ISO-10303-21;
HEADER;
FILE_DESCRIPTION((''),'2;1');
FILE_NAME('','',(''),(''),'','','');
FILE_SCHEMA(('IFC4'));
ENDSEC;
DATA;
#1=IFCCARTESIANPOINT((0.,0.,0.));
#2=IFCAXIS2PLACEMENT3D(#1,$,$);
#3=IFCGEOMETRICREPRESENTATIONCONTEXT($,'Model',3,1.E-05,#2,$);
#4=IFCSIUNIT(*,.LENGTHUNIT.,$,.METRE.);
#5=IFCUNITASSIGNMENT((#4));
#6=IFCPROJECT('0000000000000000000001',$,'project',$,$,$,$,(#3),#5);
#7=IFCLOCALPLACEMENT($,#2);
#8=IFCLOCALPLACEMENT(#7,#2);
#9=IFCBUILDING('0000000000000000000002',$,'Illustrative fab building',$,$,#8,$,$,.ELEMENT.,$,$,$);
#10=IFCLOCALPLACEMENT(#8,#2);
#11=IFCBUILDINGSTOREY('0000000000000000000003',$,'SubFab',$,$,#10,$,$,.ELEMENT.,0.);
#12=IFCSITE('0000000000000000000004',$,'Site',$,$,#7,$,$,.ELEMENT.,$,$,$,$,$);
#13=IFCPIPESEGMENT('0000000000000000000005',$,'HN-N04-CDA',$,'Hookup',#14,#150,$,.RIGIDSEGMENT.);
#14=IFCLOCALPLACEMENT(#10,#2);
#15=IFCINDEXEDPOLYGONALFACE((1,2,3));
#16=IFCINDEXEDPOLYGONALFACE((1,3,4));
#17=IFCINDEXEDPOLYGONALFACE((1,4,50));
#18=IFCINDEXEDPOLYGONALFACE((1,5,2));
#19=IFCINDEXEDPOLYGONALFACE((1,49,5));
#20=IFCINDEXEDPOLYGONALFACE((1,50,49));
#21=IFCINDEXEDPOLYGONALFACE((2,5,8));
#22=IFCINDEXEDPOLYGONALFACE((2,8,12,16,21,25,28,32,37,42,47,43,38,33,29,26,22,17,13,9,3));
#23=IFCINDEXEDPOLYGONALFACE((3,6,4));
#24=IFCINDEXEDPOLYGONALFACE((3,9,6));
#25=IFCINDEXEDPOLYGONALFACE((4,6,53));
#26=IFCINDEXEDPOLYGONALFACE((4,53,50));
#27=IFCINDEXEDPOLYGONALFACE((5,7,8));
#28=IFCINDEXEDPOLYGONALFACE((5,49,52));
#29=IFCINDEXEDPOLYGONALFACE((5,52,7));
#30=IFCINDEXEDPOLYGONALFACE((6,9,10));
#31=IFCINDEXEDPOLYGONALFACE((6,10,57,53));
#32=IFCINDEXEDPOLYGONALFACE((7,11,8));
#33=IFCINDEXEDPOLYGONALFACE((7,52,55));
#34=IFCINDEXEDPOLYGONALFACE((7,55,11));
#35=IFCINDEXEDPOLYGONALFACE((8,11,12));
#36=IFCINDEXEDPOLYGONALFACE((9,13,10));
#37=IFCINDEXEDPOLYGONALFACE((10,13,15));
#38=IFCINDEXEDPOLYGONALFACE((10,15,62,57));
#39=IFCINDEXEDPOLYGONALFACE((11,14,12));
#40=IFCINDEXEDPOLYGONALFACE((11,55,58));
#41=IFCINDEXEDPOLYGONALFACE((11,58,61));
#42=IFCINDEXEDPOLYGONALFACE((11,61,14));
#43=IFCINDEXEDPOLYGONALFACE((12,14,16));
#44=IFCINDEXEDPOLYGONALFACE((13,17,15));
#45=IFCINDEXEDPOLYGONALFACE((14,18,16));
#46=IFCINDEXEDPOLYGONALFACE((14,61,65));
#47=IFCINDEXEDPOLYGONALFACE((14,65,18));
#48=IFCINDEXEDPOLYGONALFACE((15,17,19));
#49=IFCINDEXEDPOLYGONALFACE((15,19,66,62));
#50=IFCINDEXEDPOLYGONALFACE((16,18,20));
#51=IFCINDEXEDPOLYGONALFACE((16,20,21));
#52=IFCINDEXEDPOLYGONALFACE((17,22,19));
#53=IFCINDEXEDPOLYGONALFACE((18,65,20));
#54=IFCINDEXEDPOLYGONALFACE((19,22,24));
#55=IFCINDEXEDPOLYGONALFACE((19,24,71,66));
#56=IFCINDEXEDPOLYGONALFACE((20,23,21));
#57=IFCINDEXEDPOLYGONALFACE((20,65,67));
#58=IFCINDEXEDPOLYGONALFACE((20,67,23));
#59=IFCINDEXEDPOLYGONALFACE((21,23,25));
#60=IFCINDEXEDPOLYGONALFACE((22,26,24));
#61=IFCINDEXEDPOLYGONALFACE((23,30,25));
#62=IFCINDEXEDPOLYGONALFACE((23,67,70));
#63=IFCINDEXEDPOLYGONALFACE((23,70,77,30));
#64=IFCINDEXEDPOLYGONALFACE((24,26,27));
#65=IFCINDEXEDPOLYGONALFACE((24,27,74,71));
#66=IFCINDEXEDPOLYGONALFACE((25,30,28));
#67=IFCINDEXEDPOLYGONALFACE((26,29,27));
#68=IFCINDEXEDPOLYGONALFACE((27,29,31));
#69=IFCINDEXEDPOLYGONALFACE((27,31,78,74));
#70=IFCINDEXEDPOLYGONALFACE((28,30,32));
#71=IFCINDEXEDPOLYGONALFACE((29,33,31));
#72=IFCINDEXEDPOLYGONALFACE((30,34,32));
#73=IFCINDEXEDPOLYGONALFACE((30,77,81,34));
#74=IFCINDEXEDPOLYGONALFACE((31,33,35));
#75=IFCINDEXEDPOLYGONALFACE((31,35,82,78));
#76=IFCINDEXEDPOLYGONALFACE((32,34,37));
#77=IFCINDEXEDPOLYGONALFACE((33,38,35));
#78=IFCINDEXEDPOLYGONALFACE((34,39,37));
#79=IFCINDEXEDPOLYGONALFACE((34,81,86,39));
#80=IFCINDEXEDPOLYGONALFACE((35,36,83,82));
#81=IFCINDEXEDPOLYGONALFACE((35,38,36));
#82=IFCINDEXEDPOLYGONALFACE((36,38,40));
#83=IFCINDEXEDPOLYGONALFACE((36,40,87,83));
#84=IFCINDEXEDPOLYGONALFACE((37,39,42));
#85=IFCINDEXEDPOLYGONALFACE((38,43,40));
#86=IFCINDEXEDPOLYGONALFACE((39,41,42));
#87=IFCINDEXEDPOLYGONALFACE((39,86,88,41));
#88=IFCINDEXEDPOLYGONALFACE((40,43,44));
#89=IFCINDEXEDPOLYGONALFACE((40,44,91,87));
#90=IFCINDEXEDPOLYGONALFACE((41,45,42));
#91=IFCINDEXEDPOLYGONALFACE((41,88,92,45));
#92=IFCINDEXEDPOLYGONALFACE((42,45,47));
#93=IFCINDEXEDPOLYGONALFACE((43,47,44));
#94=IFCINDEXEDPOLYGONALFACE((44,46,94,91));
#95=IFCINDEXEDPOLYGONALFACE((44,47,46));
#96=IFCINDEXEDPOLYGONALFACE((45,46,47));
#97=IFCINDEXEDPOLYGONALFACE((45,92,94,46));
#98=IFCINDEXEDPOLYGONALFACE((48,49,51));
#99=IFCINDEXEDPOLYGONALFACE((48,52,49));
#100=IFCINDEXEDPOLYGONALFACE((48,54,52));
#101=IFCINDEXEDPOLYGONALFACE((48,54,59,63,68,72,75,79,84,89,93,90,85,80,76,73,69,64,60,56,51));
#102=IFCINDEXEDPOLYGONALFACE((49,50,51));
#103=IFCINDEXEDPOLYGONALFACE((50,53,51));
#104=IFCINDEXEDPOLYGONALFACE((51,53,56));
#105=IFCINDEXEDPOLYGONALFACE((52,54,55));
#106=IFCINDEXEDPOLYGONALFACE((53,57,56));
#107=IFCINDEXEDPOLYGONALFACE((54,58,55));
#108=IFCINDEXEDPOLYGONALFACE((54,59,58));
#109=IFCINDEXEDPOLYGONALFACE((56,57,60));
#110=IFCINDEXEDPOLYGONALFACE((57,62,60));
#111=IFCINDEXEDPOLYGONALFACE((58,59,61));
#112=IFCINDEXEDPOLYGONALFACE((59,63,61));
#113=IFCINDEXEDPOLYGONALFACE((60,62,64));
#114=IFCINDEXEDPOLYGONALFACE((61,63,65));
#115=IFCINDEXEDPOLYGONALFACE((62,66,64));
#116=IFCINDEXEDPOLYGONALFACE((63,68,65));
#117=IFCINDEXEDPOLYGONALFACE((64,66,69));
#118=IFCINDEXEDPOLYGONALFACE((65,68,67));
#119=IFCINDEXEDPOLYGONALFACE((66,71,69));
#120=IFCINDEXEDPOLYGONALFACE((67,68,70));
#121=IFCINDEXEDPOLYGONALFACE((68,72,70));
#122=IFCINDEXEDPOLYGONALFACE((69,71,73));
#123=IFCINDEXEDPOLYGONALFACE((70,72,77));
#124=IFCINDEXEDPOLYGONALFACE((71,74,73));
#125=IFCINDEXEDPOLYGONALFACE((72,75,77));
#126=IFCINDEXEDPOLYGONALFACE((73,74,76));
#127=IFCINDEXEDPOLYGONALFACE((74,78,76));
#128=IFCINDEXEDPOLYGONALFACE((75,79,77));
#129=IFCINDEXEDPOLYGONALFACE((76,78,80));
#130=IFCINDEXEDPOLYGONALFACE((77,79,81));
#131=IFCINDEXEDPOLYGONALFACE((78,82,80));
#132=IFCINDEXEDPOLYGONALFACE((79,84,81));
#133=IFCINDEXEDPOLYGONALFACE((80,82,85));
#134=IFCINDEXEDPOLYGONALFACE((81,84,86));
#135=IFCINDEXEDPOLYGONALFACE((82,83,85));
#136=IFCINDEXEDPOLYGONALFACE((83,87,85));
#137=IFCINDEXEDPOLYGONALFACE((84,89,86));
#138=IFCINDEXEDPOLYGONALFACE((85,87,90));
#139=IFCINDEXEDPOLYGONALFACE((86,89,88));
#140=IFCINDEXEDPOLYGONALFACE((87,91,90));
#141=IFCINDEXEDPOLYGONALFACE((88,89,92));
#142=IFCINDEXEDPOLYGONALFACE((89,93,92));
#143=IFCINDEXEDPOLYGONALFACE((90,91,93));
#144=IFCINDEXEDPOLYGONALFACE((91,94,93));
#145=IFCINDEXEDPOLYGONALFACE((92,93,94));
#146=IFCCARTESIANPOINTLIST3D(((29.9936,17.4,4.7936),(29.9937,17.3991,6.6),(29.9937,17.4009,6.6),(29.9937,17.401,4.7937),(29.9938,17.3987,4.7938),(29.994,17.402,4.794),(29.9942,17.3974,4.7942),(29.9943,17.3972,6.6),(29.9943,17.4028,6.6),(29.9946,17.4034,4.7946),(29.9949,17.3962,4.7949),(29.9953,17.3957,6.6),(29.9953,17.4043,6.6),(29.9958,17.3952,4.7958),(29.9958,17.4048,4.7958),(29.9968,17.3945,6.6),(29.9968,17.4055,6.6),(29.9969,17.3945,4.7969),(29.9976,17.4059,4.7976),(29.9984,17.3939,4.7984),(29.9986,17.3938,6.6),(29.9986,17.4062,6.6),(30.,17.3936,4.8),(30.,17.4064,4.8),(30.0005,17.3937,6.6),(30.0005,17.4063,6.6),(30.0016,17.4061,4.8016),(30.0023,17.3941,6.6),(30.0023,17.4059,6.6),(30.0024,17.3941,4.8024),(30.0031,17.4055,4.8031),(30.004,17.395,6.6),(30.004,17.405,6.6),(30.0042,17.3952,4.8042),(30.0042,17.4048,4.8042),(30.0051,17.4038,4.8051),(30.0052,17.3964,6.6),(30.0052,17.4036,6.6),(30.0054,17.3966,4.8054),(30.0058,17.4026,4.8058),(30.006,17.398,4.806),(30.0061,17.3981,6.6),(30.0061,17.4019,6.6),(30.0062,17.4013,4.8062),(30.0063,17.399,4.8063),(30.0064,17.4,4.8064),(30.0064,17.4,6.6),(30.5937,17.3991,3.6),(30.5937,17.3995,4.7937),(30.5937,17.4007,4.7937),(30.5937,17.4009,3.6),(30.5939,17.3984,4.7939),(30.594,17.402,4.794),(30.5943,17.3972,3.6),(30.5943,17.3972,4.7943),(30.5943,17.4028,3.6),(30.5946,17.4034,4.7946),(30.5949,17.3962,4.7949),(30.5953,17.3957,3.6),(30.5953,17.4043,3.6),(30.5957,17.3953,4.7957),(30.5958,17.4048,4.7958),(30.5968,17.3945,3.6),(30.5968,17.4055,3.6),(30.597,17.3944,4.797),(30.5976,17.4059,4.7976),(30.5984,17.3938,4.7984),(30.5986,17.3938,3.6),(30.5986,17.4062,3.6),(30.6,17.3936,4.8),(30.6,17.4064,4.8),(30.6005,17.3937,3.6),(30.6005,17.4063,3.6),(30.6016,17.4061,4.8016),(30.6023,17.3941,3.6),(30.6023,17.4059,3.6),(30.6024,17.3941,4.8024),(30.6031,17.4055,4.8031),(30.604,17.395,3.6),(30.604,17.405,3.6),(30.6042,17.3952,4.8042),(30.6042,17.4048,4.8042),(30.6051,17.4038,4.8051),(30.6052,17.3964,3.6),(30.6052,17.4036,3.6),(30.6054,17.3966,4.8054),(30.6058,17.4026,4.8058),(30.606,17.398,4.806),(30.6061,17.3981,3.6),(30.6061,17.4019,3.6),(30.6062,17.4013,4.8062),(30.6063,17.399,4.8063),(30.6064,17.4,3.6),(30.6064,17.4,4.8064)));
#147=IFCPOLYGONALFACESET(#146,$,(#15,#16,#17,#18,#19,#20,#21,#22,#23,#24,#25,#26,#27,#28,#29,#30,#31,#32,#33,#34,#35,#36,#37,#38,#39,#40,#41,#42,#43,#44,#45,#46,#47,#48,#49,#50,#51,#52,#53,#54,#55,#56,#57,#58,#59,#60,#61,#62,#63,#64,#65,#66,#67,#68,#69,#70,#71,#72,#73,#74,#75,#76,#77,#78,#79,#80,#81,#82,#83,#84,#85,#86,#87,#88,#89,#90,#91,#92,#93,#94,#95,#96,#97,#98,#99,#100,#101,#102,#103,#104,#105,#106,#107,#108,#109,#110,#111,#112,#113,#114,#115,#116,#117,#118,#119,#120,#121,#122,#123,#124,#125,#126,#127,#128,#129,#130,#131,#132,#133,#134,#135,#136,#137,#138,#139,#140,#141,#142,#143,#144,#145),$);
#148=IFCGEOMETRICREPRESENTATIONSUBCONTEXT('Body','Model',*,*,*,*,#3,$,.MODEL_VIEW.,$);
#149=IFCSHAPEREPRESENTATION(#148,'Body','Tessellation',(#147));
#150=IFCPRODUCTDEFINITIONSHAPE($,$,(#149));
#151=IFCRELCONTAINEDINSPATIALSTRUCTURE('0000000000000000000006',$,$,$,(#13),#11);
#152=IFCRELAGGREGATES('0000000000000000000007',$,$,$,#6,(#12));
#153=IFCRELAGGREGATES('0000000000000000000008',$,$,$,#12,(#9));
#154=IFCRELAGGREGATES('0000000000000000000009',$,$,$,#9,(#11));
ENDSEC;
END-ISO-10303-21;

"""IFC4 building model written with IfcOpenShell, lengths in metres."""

from ifc_helpers import new_model, entity, si_unit, origin, place, context, subcontext, project, spatial, element, save


model = new_model("IFC4")

# Units and contexts
model_context = context("Model", 3, precision=1e-05, world=origin())
body_context = subcontext(model_context, "Body", "Model", "MODEL_VIEW")
ifc_project = project(units=[si_unit("LENGTHUNIT", "METRE")], contexts=[model_context])

# Site, building, storey
site_placement = place(None, origin())
site = spatial("IfcSite", under=ifc_project, at=site_placement, Name="Site", CompositionType="ELEMENT")
building_placement = place(site_placement, origin())
building = spatial("IfcBuilding", under=site, at=building_placement, Name="Illustrative fab building", CompositionType="ELEMENT")
storey_placement = place(building_placement, origin())
storey = spatial("IfcBuildingStorey", under=building, at=storey_placement, Name="SubFab", CompositionType="ELEMENT", Elevation=0.0)

# Pipe segment
pipe_segment_1_placement = place(storey_placement, origin())
element("IfcPipeSegment", 1, at=pipe_segment_1_placement, inside=storey, Name="HN-N04-CDA", ObjectType="Hookup", PredefinedType="RIGIDSEGMENT", context=body_context, shape_type="AdvancedSweptSolid", body=[
    entity("IfcSweptDiskSolid", entity("IfcPolyline", [entity("IfcCartesianPoint", [30.6, 17.4, 3.6]), entity("IfcCartesianPoint", [30.6, 17.4, 4.8]), entity("IfcCartesianPoint", [30.0, 17.4, 4.8]), entity("IfcCartesianPoint", [30.0, 17.4, 6.6])]), 0.0063),
])

save(model, "model.ifc")
